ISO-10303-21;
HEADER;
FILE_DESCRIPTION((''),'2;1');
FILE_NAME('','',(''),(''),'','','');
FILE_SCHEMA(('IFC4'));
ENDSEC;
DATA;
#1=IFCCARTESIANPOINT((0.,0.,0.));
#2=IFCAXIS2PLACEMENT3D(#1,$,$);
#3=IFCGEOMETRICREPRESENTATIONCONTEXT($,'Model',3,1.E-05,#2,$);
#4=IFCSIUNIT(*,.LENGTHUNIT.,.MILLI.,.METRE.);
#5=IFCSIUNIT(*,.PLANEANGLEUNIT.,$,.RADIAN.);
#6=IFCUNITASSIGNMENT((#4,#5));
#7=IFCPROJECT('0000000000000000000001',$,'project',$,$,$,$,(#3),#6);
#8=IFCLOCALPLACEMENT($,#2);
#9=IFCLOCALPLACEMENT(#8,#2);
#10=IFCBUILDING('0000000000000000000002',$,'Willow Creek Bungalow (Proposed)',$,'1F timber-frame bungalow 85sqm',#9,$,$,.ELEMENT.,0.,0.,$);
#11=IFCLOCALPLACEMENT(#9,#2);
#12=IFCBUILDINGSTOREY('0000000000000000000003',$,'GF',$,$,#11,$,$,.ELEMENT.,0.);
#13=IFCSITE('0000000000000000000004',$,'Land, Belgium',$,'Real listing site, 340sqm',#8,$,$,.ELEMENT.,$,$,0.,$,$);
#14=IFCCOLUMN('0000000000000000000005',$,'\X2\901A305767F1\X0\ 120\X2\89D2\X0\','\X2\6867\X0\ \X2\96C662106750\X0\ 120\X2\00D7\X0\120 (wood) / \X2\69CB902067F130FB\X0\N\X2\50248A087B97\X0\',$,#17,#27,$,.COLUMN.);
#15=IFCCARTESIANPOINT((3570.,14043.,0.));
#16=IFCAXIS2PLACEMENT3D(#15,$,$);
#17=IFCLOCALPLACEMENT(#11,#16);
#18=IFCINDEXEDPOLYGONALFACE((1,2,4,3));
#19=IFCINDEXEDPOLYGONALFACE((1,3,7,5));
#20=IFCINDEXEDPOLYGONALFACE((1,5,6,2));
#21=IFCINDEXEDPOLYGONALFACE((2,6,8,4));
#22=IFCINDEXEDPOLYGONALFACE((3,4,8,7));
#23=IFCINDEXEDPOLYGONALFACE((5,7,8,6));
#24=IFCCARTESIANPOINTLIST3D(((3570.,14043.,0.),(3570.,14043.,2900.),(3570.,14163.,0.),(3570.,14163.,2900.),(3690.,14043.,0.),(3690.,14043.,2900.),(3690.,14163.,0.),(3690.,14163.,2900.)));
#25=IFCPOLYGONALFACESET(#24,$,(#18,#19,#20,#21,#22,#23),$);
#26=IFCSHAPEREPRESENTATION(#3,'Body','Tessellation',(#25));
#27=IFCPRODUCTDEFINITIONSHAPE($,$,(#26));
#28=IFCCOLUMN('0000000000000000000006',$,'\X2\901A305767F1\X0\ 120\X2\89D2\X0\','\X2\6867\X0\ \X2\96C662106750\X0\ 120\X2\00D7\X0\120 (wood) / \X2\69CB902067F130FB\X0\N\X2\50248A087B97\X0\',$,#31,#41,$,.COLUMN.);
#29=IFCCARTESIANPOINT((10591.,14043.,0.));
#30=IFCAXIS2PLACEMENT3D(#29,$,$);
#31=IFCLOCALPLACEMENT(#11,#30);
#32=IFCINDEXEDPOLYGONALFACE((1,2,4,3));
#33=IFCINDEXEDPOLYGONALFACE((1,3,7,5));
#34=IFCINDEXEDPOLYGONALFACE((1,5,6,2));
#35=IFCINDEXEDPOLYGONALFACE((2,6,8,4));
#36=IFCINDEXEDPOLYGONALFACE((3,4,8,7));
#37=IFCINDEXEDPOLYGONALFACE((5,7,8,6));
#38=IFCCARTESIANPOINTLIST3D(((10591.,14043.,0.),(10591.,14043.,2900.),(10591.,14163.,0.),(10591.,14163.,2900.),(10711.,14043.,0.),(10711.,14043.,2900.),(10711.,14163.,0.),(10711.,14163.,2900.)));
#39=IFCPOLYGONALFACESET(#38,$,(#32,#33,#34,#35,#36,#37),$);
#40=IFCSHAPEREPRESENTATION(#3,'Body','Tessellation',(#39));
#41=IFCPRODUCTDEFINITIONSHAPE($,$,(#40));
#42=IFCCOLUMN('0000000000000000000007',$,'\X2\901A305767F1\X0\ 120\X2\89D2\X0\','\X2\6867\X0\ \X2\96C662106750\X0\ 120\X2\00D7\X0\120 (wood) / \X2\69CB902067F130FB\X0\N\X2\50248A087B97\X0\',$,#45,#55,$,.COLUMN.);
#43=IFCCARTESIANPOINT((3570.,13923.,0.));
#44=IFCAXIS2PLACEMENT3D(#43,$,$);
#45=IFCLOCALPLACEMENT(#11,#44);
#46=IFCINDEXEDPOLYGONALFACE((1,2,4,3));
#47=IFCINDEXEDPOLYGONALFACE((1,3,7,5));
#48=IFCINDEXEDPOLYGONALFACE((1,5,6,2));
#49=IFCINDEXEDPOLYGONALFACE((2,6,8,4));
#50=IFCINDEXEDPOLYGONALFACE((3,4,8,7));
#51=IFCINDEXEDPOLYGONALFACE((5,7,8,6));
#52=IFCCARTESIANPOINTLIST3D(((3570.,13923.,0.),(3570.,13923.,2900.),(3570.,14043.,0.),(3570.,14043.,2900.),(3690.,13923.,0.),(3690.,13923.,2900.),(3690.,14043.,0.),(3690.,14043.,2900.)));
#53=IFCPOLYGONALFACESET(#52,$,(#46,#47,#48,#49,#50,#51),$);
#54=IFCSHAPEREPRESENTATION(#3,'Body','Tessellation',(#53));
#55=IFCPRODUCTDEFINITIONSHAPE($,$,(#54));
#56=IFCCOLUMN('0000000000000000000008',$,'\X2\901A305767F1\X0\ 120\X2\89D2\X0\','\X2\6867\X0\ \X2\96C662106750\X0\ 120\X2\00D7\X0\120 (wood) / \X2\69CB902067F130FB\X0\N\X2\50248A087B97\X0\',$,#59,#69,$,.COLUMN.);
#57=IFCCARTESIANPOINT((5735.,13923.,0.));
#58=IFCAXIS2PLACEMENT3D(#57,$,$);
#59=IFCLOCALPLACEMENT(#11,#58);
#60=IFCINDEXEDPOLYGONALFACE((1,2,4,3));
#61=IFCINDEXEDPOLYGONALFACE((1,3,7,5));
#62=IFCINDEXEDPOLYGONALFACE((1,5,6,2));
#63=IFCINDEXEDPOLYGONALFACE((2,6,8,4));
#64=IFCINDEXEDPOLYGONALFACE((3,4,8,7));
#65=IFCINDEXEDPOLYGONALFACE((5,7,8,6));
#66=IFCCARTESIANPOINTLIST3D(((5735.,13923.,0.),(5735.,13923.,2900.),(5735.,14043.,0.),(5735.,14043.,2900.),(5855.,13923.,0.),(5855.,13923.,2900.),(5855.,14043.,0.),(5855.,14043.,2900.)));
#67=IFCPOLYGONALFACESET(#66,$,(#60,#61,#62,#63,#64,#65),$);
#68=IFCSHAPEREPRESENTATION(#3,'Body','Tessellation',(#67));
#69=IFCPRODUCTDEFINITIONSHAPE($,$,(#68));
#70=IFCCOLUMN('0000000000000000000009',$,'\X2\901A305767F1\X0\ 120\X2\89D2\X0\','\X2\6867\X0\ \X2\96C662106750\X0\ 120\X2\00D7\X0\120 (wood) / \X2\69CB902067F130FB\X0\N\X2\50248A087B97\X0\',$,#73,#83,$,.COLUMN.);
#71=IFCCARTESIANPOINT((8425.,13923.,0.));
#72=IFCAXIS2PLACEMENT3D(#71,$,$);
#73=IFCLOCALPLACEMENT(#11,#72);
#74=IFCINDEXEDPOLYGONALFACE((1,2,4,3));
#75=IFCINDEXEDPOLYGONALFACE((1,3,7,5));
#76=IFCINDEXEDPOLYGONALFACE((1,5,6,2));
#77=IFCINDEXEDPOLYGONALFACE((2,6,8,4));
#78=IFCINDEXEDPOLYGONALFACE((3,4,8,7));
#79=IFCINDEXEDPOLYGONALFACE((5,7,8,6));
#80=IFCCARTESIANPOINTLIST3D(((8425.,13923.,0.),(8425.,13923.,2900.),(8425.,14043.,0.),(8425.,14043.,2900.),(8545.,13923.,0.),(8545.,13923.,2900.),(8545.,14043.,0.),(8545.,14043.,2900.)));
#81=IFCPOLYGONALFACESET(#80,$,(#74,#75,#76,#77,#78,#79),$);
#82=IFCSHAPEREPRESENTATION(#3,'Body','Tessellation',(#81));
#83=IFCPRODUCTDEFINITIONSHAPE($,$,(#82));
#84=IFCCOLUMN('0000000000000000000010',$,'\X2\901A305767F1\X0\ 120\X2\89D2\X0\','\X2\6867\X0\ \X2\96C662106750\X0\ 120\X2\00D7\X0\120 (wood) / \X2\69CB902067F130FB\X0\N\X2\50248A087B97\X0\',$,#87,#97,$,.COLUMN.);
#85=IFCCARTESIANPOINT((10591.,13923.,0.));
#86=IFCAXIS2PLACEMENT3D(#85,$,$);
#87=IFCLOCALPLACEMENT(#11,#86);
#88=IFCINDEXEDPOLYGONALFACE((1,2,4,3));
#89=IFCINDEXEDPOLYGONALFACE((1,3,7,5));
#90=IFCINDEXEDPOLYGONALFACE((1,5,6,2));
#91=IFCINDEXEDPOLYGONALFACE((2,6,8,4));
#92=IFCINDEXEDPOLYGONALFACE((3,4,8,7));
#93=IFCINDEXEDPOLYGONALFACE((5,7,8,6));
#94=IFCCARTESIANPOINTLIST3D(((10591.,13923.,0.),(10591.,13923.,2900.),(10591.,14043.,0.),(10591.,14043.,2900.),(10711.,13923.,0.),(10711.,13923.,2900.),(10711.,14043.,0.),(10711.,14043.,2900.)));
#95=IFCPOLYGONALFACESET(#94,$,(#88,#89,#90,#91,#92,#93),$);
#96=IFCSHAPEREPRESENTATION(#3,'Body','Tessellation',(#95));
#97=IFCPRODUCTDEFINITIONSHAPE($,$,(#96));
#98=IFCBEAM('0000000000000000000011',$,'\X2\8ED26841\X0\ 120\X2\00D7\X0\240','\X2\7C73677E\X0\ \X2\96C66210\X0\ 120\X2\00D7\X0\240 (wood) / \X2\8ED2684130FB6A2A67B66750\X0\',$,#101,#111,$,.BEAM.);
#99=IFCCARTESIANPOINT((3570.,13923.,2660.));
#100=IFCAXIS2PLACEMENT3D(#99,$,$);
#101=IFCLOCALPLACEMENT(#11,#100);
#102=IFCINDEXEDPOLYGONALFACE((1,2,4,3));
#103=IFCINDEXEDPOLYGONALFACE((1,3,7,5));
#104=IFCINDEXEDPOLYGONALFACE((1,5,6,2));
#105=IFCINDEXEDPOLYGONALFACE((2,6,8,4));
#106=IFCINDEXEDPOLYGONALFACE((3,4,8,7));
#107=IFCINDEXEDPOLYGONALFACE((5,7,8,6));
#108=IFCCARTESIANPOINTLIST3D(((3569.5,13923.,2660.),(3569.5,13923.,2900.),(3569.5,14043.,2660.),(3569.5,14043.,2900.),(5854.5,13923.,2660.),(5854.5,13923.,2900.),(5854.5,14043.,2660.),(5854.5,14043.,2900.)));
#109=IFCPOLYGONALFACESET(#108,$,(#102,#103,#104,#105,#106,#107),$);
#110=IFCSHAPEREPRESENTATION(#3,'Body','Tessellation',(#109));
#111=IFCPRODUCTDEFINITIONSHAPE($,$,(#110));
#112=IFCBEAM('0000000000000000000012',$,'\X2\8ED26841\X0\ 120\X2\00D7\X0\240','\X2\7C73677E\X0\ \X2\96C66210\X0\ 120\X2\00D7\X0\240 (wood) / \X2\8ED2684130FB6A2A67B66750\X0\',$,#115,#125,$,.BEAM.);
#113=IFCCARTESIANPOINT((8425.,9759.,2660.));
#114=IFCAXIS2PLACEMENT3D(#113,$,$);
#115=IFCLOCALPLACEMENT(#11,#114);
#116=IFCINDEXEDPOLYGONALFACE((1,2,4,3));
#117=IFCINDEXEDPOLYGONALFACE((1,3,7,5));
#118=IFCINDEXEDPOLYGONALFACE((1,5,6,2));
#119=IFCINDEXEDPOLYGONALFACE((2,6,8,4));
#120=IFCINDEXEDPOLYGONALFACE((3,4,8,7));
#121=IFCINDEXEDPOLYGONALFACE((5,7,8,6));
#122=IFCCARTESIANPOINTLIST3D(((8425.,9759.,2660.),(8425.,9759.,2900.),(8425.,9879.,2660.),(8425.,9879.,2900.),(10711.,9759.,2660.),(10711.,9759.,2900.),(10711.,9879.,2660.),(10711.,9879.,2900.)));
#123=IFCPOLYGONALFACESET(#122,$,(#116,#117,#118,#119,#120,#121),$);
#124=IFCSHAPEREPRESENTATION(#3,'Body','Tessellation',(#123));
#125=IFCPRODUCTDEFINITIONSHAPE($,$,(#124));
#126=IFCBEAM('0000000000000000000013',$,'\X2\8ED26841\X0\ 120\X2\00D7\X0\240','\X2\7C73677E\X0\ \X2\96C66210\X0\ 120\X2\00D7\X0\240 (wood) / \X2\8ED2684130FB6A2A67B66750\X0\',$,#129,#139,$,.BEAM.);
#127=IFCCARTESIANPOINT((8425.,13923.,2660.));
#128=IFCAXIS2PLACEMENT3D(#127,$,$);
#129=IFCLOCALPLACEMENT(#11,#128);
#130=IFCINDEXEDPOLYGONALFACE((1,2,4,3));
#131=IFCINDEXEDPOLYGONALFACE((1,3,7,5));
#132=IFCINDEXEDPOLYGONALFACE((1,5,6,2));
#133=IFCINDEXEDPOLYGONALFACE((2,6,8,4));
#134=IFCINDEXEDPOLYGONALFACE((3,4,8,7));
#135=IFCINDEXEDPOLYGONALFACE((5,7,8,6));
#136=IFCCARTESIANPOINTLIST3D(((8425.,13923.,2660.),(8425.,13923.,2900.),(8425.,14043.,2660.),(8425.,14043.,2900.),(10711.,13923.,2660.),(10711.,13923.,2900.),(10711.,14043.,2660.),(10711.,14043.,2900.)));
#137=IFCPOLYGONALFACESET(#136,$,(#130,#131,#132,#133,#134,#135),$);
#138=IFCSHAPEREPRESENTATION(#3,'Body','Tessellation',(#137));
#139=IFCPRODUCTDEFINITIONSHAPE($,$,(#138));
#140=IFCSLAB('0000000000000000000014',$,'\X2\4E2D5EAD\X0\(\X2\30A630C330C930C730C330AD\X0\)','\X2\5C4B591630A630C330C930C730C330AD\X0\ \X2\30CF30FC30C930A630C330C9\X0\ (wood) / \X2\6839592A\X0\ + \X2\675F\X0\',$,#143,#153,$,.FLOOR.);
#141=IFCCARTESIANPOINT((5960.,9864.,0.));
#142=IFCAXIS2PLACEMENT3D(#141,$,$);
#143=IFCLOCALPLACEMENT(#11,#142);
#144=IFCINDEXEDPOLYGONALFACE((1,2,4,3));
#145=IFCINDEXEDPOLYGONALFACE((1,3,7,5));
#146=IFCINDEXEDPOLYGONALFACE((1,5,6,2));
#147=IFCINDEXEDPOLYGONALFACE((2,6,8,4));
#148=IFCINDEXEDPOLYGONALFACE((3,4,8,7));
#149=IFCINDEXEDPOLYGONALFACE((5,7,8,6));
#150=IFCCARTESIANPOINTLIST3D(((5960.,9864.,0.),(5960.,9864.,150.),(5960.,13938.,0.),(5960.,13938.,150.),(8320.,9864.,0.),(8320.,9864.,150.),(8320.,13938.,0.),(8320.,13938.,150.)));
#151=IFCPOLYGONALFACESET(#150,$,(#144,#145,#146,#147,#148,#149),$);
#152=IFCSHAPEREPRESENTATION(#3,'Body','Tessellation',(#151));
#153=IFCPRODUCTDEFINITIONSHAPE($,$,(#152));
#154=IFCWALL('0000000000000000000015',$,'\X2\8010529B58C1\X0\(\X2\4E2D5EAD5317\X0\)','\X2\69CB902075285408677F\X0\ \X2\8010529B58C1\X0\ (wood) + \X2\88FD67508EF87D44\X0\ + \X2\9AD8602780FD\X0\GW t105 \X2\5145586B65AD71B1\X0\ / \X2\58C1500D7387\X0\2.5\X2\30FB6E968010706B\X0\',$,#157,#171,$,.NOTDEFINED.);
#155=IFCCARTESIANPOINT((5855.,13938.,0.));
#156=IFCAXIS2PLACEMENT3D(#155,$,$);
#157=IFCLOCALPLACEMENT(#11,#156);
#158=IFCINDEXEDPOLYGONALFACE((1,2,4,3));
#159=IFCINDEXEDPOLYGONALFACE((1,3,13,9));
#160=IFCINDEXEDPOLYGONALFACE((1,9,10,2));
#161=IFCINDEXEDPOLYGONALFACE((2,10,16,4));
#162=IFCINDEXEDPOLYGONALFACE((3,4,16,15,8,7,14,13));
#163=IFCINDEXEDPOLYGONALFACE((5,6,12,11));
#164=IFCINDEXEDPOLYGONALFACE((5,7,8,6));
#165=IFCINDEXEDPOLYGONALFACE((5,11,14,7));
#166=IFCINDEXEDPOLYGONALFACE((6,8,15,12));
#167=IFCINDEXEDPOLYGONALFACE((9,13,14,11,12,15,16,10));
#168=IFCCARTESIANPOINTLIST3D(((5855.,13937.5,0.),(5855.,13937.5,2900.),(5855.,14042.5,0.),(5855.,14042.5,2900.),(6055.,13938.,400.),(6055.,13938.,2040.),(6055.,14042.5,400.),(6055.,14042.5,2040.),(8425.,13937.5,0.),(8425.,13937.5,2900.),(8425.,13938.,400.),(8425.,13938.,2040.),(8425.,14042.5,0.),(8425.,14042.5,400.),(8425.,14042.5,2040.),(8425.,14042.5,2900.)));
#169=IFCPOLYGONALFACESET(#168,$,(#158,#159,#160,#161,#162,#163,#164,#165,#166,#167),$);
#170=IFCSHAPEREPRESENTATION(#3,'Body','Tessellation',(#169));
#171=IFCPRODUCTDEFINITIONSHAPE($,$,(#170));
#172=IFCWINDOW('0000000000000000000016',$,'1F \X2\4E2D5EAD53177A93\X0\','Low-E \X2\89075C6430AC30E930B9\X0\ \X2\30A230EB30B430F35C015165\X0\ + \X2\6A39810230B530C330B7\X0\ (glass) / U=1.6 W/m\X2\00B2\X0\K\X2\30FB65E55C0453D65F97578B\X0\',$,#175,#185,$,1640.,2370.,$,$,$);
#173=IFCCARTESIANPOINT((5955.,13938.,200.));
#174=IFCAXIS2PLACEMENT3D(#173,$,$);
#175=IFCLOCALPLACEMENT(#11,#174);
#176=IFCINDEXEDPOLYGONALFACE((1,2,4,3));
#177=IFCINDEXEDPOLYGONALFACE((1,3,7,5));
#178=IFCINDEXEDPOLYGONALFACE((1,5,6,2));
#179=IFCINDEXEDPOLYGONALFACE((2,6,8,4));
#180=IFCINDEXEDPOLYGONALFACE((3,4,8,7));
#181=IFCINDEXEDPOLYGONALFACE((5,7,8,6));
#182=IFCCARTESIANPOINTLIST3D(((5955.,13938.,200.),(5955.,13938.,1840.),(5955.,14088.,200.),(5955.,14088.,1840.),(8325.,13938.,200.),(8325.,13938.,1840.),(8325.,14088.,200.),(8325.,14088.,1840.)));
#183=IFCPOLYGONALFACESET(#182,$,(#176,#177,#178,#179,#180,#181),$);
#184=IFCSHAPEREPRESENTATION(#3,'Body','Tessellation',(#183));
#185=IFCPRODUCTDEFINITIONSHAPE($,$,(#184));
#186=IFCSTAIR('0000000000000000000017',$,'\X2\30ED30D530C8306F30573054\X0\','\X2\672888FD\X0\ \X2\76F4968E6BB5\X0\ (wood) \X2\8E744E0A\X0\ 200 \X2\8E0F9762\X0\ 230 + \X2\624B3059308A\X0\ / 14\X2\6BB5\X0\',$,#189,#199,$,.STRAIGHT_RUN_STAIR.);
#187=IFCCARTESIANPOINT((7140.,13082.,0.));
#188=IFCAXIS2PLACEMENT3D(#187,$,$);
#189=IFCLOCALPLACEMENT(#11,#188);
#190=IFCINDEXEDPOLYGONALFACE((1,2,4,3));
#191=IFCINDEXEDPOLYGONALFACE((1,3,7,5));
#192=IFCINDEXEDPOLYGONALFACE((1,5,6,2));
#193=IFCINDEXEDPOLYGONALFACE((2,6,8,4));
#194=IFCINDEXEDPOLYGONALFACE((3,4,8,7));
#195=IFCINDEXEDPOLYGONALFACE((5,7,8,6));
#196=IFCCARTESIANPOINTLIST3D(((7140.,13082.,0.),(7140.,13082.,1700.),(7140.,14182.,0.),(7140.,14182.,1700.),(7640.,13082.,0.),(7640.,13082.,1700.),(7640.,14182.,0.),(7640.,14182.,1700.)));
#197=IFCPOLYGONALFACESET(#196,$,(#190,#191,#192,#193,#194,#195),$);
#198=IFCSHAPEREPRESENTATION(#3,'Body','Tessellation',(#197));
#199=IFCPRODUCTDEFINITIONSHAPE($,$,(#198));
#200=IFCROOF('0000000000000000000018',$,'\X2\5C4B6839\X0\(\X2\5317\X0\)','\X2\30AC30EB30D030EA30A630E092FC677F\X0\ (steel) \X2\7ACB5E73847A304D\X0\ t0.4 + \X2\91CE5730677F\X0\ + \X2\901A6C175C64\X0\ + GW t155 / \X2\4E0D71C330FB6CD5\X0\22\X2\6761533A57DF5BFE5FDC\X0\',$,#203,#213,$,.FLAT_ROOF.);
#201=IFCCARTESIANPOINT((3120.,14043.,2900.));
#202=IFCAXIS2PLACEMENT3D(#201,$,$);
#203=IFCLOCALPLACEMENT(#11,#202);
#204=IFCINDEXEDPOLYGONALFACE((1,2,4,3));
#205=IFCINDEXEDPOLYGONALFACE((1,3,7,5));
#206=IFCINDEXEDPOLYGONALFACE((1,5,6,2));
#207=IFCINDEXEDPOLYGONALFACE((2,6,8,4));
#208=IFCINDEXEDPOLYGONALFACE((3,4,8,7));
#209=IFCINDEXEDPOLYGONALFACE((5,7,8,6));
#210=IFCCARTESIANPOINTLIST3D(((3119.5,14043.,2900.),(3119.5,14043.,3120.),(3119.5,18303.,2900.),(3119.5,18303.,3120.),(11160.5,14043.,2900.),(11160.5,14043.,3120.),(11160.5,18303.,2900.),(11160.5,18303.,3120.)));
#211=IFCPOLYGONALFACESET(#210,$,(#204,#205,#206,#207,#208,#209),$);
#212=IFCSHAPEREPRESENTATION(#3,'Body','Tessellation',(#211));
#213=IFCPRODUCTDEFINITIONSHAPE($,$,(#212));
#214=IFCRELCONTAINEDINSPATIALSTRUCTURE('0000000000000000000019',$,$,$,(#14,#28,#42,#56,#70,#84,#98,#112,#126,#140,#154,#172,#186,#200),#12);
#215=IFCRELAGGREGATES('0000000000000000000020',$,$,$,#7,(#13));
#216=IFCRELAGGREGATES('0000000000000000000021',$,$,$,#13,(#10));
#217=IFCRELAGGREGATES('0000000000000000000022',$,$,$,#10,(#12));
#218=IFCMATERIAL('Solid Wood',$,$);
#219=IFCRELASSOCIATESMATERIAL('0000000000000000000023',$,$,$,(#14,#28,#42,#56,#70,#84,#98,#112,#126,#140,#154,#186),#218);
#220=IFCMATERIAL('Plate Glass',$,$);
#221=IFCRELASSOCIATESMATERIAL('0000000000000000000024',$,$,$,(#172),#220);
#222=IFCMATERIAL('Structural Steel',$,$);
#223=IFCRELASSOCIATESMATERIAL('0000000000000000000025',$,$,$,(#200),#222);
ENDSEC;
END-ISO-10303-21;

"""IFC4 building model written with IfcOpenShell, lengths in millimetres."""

from ifc_helpers import new_model, si_unit, frame, frame_2d, origin, place, context, project, spatial, rectangle, extrude, material, element, fill, save


model = new_model("IFC4")

# Units and contexts
model_context = context("Model", 3, precision=1e-05, world=origin())
ifc_project = project(units=[si_unit("LENGTHUNIT", "METRE", prefix="MILLI"), si_unit("PLANEANGLEUNIT", "RADIAN")], contexts=[model_context])

# Site, building, storey
site_placement = place(None, origin())
site = spatial("IfcSite", under=ifc_project, at=site_placement, Name="Land, Belgium", ObjectType="Real listing site, 340sqm", CompositionType="ELEMENT", RefElevation=0.0)
building_placement = place(site_placement, origin())
building = spatial("IfcBuilding", under=site, at=building_placement, Name="Willow Creek Bungalow (Proposed)", ObjectType="1F timber-frame bungalow 85sqm", CompositionType="ELEMENT", ElevationOfRefHeight=0.0, ElevationOfTerrain=0.0)
storey_placement = place(building_placement, origin())
storey = spatial("IfcBuildingStorey", under=building, at=storey_placement, Name="GF", CompositionType="ELEMENT", Elevation=0.0)

# Columns
ifc_material_1 = material(Name="Solid Wood")
column_1_placement = place(storey_placement, frame((3570.0, 14043.0, 0.0)))
element("IfcColumn", 1, at=column_1_placement, inside=storey, material=ifc_material_1, Name="通し柱 120角", Description="桧 集成材 120×120 (wood) / 構造柱・N値計算", PredefinedType="COLUMN", context=model_context, shape_type="SweptSolid", body=[
    extrude(rectangle(XDim=120.0, YDim=120.0, at=frame_2d((60.0, 60.0))), frame((3570.0, 14043.0, 0.0)), (0.0, 0.0, 1.0), 2900.0),
])
column_2_placement = place(storey_placement, frame((10591.0, 14043.0, 0.0)))
element("IfcColumn", 2, at=column_2_placement, inside=storey, material=ifc_material_1, Name="通し柱 120角", Description="桧 集成材 120×120 (wood) / 構造柱・N値計算", PredefinedType="COLUMN", context=model_context, shape_type="SweptSolid", body=[
    extrude(rectangle(XDim=120.0, YDim=120.0, at=frame_2d((60.0, 60.0))), frame((10591.0, 14043.0, 0.0)), (0.0, 0.0, 1.0), 2900.0),
])
column_3_placement = place(storey_placement, frame((3570.0, 13923.0, 0.0)))
element("IfcColumn", 3, at=column_3_placement, inside=storey, material=ifc_material_1, Name="通し柱 120角", Description="桧 集成材 120×120 (wood) / 構造柱・N値計算", PredefinedType="COLUMN", context=model_context, shape_type="SweptSolid", body=[
    extrude(rectangle(XDim=120.0, YDim=120.0, at=frame_2d((60.0, 60.0))), frame((3570.0, 13923.0, 0.0)), (0.0, 0.0, 1.0), 2900.0),
])
column_4_placement = place(storey_placement, frame((5735.0, 13923.0, 0.0)))
element("IfcColumn", 4, at=column_4_placement, inside=storey, material=ifc_material_1, Name="通し柱 120角", Description="桧 集成材 120×120 (wood) / 構造柱・N値計算", PredefinedType="COLUMN", context=model_context, shape_type="SweptSolid", body=[
    extrude(rectangle(XDim=120.0, YDim=120.0, at=frame_2d((60.0, 60.0))), frame((5735.0, 13923.0, 0.0)), (0.0, 0.0, 1.0), 2900.0),
])
column_5_placement = place(storey_placement, frame((8425.0, 13923.0, 0.0)))
element("IfcColumn", 5, at=column_5_placement, inside=storey, material=ifc_material_1, Name="通し柱 120角", Description="桧 集成材 120×120 (wood) / 構造柱・N値計算", PredefinedType="COLUMN", context=model_context, shape_type="SweptSolid", body=[
    extrude(rectangle(XDim=120.0, YDim=120.0, at=frame_2d((60.0, 60.0))), frame((8425.0, 13923.0, 0.0)), (0.0, 0.0, 1.0), 2900.0),
])
column_6_placement = place(storey_placement, frame((10591.0, 13923.0, 0.0)))
element("IfcColumn", 6, at=column_6_placement, inside=storey, material=ifc_material_1, Name="通し柱 120角", Description="桧 集成材 120×120 (wood) / 構造柱・N値計算", PredefinedType="COLUMN", context=model_context, shape_type="SweptSolid", body=[
    extrude(rectangle(XDim=120.0, YDim=120.0, at=frame_2d((60.0, 60.0))), frame((10591.0, 13923.0, 0.0)), (0.0, 0.0, 1.0), 2900.0),
])

# Beams
beam_1_placement = place(storey_placement, frame((3570.0, 13923.0, 2660.0)))
element("IfcBeam", 7, at=beam_1_placement, inside=storey, material=ifc_material_1, Name="軒桁 120×240", Description="米松 集成 120×240 (wood) / 軒桁・横架材", PredefinedType="BEAM", context=model_context, shape_type="SweptSolid", body=[
    extrude(rectangle(XDim=2285.0, YDim=120.0, at=frame_2d((1142.0, 60.0))), frame((3570.0, 13923.0, 2660.0)), (0.0, 0.0, 1.0), 240.0),
])
beam_2_placement = place(storey_placement, frame((8425.0, 9759.0, 2660.0)))
element("IfcBeam", 8, at=beam_2_placement, inside=storey, material=ifc_material_1, Name="軒桁 120×240", Description="米松 集成 120×240 (wood) / 軒桁・横架材", PredefinedType="BEAM", context=model_context, shape_type="SweptSolid", body=[
    extrude(rectangle(XDim=2286.0, YDim=120.0, at=frame_2d((1143.0, 60.0))), frame((8425.0, 9759.0, 2660.0)), (0.0, 0.0, 1.0), 240.0),
])
beam_3_placement = place(storey_placement, frame((8425.0, 13923.0, 2660.0)))
element("IfcBeam", 9, at=beam_3_placement, inside=storey, material=ifc_material_1, Name="軒桁 120×240", Description="米松 集成 120×240 (wood) / 軒桁・横架材", PredefinedType="BEAM", context=model_context, shape_type="SweptSolid", body=[
    extrude(rectangle(XDim=2286.0, YDim=120.0, at=frame_2d((1143.0, 60.0))), frame((8425.0, 13923.0, 2660.0)), (0.0, 0.0, 1.0), 240.0),
])

# Slab
slab_1_placement = place(storey_placement, frame((5960.0, 9864.0, 0.0)))
element("IfcSlab", 10, at=slab_1_placement, inside=storey, material=ifc_material_1, Name="中庭(ウッドデッキ)", Description="屋外ウッドデッキ ハードウッド (wood) / 根太 + 束", PredefinedType="FLOOR", context=model_context, shape_type="SweptSolid", body=[
    extrude(rectangle(XDim=2360.0, YDim=4074.0, at=frame_2d((1180.0, 2037.0))), frame((5960.0, 9864.0, 0.0)), (0.0, 0.0, 1.0), 150.0),
])

# Wall, opening, window
wall_placement = place(storey_placement, frame((5855.0, 13938.0, 0.0)))
wall = element("IfcWall", 11, at=wall_placement, inside=storey, material=ifc_material_1, Name="耐力壁(中庭北)", Description="構造用合板 耐力壁 (wood) + 製材軸組 + 高性能GW t105 充填断熱 / 壁倍率2.5・準耐火", PredefinedType="NOTDEFINED", context=model_context, shape_type="SweptSolid", body=[
    extrude(rectangle(XDim=2570.0, YDim=105.0, at=frame_2d((1285.0, 52.0))), frame((5855.0, 13938.0, 0.0)), (0.0, 0.0, 1.0), 2900.0),
])
opening_placement = place(storey_placement, frame((5955.0, 13938.0, 200.0)))
opening = element("IfcOpeningElement", 12, at=opening_placement, cuts=wall, PredefinedType="NOTDEFINED", context=model_context, shape_type="SweptSolid", body=[
    extrude(rectangle(XDim=2370.0, YDim=150.0, at=frame_2d((1185.0, 75.0))), frame((5955.0, 13938.0, 200.0)), (0.0, 0.0, 1.0), 1640.0),
])
ifc_material_2 = material(Name="Plate Glass")
window_placement = place(storey_placement, frame((5955.0, 13938.0, 200.0)))
window = element("IfcWindow", 13, at=window_placement, inside=storey, material=ifc_material_2, Name="1F 中庭北窓", Description="Low-E 複層ガラス アルゴン封入 + 樹脂サッシ (glass) / U=1.6 W/m²K・日射取得型", OverallHeight=1640.0, OverallWidth=2370.0, context=model_context, shape_type="SweptSolid", body=[
    extrude(rectangle(XDim=2370.0, YDim=150.0, at=frame_2d((1185.0, 75.0))), frame((5955.0, 13938.0, 200.0)), (0.0, 0.0, 1.0), 1640.0),
])
fill(opening, window)

# Stair
stair_placement = place(storey_placement, frame((7140.0, 13082.0, 0.0)))
element("IfcStair", 14, at=stair_placement, inside=storey, material=ifc_material_1, Name="ロフトはしご", Description="木製 直階段 (wood) 蹴上 200 踏面 230 + 手すり / 14段", PredefinedType="STRAIGHT_RUN_STAIR", context=model_context, shape_type="SweptSolid", body=[
    extrude(rectangle(XDim=500.0, YDim=1100.0, at=frame_2d((250.0, 550.0))), frame((7140.0, 13082.0, 0.0)), (0.0, 0.0, 1.0), 1700.0),
])

# Roof
ifc_material_3 = material(Name="Structural Steel")
roof_placement = place(storey_placement, frame((3120.0, 14043.0, 2900.0)))
element("IfcRoof", 15, at=roof_placement, inside=storey, material=ifc_material_3, Name="屋根(北)", Description="ガルバリウム鋼板 (steel) 立平葺き t0.4 + 野地板 + 通気層 + GW t155 / 不燃・法22条区域対応", PredefinedType="FLAT_ROOF", context=model_context, shape_type="SweptSolid", body=[
    extrude(rectangle(XDim=8041.0, YDim=4260.0, at=frame_2d((4020.0, 2130.0))), frame((3120.0, 14043.0, 2900.0)), (0.0, 0.0, 1.0), 220.0),
])

save(model, "model.ifc")
